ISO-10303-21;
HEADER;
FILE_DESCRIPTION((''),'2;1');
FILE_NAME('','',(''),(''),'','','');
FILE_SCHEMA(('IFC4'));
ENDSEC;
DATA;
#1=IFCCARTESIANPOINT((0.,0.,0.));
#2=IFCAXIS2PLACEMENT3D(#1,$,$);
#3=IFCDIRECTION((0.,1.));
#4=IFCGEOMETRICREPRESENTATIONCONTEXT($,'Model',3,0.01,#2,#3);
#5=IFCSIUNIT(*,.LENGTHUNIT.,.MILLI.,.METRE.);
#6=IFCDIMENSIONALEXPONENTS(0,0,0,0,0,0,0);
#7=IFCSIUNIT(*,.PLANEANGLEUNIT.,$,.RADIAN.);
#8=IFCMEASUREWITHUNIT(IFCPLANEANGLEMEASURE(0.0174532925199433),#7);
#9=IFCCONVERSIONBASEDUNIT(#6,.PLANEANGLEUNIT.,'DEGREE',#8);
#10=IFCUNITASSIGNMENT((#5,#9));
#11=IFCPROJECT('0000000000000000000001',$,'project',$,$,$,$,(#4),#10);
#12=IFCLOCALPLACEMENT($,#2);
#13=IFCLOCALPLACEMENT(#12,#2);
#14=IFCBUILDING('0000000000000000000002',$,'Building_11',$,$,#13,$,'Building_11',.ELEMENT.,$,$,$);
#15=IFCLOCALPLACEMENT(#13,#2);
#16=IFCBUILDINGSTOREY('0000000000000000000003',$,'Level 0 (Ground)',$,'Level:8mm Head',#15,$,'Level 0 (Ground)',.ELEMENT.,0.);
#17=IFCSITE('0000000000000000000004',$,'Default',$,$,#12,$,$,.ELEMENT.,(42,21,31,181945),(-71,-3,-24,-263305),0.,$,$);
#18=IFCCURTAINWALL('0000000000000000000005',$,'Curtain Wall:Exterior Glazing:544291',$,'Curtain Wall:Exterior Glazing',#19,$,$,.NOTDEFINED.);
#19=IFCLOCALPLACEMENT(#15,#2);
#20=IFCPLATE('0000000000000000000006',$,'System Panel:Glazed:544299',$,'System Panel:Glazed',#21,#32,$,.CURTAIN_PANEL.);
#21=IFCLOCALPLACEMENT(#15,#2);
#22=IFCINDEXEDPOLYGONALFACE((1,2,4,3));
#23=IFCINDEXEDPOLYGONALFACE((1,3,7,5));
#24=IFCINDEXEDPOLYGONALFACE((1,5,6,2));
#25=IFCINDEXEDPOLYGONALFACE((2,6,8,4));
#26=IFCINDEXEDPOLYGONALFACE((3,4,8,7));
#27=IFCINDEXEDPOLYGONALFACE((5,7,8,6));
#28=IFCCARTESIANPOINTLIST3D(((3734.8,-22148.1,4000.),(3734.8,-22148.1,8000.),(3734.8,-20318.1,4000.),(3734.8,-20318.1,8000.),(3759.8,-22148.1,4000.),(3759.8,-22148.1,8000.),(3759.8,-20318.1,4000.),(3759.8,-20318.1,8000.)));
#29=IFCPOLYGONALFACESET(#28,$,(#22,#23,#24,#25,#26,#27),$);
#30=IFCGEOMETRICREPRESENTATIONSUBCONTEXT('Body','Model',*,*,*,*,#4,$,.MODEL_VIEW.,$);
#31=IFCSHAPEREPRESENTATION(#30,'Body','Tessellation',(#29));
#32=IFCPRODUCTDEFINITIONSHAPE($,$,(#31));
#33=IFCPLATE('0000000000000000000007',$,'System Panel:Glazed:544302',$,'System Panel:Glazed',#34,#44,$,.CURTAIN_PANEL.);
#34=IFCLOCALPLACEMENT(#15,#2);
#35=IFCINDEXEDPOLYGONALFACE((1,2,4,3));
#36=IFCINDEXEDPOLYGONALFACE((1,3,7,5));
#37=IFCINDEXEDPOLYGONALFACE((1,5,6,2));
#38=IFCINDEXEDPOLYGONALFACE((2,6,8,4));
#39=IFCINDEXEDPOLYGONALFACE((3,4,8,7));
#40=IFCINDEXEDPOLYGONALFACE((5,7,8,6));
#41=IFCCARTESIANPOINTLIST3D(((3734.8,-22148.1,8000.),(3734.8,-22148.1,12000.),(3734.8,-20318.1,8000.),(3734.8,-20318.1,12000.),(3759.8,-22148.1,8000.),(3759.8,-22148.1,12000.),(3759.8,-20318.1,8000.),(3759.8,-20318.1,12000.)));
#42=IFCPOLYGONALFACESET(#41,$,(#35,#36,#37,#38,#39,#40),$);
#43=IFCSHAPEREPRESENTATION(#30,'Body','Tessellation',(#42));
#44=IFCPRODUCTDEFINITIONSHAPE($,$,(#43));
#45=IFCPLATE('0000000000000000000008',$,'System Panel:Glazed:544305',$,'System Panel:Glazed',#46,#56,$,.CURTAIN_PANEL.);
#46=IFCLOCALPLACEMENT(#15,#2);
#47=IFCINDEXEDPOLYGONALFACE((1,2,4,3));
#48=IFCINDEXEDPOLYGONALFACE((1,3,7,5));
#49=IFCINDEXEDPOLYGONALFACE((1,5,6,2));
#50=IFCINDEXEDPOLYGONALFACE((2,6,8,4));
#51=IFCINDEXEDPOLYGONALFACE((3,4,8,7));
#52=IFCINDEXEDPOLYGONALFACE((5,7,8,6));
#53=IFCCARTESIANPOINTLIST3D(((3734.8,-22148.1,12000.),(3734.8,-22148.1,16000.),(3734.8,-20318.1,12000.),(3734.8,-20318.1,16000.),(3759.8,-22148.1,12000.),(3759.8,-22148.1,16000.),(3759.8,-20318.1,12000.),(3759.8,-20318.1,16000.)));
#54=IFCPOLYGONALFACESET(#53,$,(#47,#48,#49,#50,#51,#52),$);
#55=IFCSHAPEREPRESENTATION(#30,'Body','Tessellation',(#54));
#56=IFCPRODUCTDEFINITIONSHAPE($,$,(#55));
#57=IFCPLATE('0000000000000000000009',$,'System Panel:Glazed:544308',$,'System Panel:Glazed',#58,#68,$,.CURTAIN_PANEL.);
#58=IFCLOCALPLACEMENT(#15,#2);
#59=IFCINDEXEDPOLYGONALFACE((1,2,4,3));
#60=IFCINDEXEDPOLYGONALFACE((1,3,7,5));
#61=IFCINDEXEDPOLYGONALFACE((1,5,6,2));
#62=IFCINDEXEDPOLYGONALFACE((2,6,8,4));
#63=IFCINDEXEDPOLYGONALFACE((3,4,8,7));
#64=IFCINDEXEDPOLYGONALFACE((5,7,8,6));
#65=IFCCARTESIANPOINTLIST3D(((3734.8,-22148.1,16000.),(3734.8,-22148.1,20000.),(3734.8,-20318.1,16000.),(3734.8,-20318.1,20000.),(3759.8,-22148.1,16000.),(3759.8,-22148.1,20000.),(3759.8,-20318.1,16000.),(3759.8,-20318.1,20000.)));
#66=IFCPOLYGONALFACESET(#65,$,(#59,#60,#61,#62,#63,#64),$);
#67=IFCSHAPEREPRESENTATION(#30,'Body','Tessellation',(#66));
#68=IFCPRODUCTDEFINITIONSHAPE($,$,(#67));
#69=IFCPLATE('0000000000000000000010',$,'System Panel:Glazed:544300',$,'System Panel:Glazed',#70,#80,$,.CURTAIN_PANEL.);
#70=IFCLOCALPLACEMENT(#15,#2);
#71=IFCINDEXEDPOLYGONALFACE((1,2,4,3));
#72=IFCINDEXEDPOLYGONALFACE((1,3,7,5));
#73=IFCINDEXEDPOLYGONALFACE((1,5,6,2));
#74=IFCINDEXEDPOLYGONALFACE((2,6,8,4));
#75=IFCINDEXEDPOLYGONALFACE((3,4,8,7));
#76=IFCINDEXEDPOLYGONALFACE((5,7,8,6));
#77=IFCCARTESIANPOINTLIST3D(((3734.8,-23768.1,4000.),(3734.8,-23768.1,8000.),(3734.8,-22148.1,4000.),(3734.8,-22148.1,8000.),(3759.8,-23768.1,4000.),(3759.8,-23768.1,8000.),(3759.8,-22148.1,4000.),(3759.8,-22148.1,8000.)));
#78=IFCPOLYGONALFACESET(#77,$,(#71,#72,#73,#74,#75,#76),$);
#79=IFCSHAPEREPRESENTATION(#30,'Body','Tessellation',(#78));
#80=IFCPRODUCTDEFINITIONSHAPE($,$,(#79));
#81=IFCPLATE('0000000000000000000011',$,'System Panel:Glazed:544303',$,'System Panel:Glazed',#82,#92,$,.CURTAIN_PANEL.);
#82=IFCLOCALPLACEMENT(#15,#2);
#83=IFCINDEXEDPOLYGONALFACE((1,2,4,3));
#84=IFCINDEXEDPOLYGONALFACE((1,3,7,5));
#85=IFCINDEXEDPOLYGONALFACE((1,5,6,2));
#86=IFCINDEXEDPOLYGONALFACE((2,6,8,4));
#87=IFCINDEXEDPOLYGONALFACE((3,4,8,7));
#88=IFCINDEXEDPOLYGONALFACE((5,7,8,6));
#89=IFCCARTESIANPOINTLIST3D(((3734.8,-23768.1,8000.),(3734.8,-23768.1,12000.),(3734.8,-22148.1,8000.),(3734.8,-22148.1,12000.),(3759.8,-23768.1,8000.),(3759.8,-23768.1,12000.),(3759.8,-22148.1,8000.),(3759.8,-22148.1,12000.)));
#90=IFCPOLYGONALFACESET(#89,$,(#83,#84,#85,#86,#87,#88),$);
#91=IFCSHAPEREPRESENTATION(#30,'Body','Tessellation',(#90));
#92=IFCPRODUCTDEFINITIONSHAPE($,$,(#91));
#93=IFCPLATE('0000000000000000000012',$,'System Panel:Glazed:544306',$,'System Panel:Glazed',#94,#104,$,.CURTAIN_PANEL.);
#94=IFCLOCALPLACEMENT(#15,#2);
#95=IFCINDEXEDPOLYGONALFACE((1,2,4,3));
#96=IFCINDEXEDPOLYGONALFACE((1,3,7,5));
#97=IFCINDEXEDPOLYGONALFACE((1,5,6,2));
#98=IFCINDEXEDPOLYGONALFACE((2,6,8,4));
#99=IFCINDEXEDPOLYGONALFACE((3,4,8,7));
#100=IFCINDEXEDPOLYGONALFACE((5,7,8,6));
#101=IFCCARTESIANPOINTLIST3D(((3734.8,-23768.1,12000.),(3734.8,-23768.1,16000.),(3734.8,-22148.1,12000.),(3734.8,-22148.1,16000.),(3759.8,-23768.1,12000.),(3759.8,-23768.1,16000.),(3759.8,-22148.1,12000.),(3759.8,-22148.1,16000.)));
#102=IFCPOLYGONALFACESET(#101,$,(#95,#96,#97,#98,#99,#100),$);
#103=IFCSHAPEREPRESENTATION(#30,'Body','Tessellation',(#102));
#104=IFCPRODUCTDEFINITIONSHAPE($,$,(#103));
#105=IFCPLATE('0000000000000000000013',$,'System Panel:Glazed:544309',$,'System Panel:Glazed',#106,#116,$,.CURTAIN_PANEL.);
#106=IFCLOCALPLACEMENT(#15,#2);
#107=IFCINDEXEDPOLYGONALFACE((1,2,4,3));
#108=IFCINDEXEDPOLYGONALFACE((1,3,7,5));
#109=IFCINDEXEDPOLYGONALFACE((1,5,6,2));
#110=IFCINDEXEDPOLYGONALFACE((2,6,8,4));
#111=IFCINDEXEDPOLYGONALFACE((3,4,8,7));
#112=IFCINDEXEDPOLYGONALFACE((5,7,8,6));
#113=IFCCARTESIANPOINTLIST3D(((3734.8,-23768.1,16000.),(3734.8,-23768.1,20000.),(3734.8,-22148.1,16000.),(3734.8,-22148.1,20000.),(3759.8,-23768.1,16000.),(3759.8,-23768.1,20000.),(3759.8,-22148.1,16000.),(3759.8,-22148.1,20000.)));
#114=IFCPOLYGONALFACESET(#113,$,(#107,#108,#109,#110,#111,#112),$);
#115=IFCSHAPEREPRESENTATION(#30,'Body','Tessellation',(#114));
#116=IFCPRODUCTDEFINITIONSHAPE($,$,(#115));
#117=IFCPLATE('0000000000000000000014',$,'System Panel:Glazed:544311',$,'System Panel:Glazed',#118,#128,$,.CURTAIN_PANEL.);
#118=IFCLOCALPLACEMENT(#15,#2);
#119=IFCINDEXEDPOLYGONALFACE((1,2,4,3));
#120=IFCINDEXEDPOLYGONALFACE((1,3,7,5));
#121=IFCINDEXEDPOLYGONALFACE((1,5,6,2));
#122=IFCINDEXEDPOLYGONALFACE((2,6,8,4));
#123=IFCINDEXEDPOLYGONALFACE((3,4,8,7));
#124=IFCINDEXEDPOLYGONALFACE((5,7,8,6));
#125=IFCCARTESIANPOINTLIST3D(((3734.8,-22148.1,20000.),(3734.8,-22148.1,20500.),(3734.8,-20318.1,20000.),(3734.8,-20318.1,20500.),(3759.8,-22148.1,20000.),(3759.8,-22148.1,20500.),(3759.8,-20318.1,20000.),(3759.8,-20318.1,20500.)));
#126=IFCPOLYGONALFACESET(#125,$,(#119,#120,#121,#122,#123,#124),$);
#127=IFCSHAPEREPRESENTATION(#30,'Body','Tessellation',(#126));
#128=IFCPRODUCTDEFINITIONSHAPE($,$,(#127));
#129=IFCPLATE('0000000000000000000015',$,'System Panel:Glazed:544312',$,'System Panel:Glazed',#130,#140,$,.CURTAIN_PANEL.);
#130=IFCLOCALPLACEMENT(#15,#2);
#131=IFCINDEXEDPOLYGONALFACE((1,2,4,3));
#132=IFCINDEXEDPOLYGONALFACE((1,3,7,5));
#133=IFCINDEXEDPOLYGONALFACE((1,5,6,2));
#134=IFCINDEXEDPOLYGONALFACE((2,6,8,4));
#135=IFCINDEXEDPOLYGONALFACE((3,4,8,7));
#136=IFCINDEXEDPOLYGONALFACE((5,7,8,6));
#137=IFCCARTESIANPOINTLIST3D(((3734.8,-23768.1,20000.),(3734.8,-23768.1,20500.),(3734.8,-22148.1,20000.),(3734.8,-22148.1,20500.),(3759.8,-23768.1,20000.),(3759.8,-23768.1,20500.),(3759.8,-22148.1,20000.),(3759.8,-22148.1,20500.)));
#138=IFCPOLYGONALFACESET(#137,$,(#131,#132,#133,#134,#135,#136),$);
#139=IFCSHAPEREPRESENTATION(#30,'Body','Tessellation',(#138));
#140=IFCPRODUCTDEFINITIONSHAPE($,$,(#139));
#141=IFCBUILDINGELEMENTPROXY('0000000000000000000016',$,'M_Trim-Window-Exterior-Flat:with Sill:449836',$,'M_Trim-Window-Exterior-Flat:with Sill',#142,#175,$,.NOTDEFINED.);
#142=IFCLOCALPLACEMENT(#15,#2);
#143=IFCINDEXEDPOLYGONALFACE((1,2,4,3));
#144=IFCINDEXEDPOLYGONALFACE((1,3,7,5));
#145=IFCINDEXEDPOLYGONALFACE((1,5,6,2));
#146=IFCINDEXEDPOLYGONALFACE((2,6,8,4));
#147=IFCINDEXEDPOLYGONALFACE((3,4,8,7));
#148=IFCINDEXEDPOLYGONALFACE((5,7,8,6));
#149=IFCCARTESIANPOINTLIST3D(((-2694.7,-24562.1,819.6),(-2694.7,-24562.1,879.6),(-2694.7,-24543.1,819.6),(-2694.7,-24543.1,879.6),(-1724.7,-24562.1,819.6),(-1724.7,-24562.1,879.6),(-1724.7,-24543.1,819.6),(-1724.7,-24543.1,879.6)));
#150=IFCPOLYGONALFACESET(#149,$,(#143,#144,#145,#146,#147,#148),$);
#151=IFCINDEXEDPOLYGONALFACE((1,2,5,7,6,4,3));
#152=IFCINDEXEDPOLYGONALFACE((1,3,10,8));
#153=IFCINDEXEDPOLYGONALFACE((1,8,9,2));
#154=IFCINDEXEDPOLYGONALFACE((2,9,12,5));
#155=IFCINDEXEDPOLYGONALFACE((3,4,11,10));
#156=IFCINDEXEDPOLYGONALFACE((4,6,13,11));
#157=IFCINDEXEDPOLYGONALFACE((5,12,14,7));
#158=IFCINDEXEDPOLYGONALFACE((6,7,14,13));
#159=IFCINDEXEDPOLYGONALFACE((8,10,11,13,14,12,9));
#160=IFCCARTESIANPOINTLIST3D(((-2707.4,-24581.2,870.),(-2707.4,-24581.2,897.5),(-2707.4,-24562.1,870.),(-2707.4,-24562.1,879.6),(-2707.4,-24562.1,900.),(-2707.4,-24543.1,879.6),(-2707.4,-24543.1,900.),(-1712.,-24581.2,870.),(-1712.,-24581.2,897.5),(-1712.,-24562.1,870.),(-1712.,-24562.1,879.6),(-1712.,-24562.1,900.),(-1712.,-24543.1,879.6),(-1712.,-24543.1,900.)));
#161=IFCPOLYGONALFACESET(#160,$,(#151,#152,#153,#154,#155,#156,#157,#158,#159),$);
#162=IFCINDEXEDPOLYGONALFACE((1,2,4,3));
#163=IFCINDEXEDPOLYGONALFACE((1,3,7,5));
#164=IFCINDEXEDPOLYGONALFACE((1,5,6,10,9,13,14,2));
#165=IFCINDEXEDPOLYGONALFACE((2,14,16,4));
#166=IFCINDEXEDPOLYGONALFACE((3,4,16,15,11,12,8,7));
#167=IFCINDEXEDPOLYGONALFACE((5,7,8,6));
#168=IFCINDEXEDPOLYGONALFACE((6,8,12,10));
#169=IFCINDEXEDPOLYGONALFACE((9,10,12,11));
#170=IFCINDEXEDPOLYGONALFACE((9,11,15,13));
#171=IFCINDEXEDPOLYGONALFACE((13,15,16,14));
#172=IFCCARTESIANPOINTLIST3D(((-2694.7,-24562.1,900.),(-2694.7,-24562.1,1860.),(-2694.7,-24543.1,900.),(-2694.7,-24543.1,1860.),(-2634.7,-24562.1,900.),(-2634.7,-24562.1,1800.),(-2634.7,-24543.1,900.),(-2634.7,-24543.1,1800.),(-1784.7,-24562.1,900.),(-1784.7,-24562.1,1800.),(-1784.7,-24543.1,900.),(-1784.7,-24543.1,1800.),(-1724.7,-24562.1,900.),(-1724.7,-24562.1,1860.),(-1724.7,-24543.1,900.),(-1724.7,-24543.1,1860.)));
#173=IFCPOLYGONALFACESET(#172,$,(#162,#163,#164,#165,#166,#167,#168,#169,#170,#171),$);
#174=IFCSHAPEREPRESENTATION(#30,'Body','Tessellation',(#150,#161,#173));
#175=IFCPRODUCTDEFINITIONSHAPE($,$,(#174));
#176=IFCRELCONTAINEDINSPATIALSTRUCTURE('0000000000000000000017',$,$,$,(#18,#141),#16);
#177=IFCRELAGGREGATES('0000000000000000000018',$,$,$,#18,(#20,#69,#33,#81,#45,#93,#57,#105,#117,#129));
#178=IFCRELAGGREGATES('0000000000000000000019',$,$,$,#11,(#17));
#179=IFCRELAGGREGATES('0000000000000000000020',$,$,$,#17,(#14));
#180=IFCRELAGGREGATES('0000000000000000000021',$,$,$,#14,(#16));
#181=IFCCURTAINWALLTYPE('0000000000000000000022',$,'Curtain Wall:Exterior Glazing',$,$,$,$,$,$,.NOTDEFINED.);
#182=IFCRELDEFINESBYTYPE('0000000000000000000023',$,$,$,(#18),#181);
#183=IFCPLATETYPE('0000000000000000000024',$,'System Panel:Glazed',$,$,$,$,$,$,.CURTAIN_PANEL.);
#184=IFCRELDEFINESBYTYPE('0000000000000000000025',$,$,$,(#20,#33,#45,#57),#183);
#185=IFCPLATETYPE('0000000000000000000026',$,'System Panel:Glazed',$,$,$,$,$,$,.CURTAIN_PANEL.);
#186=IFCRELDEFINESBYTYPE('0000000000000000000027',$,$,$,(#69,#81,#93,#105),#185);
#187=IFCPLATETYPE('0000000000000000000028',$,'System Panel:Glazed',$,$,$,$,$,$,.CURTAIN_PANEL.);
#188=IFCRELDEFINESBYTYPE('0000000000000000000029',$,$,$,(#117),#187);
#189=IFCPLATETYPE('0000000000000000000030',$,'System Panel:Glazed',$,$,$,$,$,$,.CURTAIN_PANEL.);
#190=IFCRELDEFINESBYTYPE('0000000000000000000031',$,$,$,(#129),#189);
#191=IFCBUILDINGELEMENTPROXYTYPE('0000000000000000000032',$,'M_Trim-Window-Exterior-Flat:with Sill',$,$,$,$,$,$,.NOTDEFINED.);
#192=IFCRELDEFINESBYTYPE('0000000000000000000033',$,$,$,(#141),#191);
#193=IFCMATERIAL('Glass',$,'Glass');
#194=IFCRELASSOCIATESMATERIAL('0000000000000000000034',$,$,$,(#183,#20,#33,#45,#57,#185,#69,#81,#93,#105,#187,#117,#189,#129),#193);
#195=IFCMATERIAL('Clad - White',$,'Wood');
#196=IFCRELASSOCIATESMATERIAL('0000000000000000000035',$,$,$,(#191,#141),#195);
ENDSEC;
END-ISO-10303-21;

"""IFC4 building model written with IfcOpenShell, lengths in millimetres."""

from ifc_helpers import new_model, entity, si_unit, converted_unit, direction, frame, origin, place, context, subcontext, project, spatial, indexed_curve, outline, extrude, source, transform, mapped, material, type_object, type_shapes, element, aggregate, save


model = new_model("IFC4")

# Units and contexts
model_context = context("Model", 3, precision=0.01, world=origin(), true_north=direction((0.0, 1.0)))
body_context = subcontext(model_context, "Body", "Model", "MODEL_VIEW")
ifc_project = project(units=[si_unit("LENGTHUNIT", "METRE", prefix="MILLI"), converted_unit("PLANEANGLEUNIT", "DEGREE", entity("IfcPlaneAngleMeasure", 0.0174532925199433), si_unit("PLANEANGLEUNIT", "RADIAN"), dimensions=[0, 0, 0, 0, 0, 0, 0])], contexts=[model_context])

# Site, building, storey
site_placement = place(None, origin())
site = spatial("IfcSite", under=ifc_project, at=site_placement, Name="Default", CompositionType="ELEMENT", RefLatitude=(42, 21, 31, 181945), RefLongitude=(-71, -3, -24, -263305), RefElevation=0.0)
building_placement = place(site_placement, origin())
building = spatial("IfcBuilding", under=site, at=building_placement, Name="Building_11", LongName="Building_11", CompositionType="ELEMENT")
storey_placement = place(building_placement, origin())
storey = spatial("IfcBuildingStorey", under=building, at=storey_placement, Name="Level 0 (Ground)", ObjectType="Level:8mm Head", LongName="Level 0 (Ground)", CompositionType="ELEMENT", Elevation=0.0)

# Curtain wall, plates
curtain_wall_type = type_object("IfcCurtainWallType", Name="Curtain Wall:Exterior Glazing", PredefinedType="NOTDEFINED")
curtain_wall_placement = place(storey_placement, origin())
curtain_wall = element("IfcCurtainWall", 1, at=curtain_wall_placement, inside=storey, type_object=curtain_wall_type, Name="Curtain Wall:Exterior Glazing:544291", ObjectType="Curtain Wall:Exterior Glazing", PredefinedType="NOTDEFINED")
ifc_material_1 = material(Name="Glass", Category="Glass")
plate_type_1 = type_object("IfcPlateType", Name="System Panel:Glazed", PredefinedType="CURTAIN_PANEL", material=ifc_material_1)
shared_shape_1 = source(origin(), body_context, "Body", "SweptSolid", [
    extrude(outline(indexed_curve([(-12.5, -915.0), (12.5, -915.0), (12.5, 915.0), (-12.5, 915.0), (-12.5, -915.0)], self_intersect=False)), frame((0.0, 37.0, 0.0), z_axis=(0.0, 0.0, 1.0), x_axis=(0.0, 1.0, 0.0)), (0.0, 0.0, 1.0), 4000.0),
])
type_shapes(plate_type_1, [shared_shape_1])
plate_1_placement = place(curtain_wall_placement, frame((3710.3, -21233.1, 4000.0), z_axis=(0.0, 0.0, 1.0), x_axis=(0.0, -1.0, 0.0)))
plate_1 = element("IfcPlate", 2, at=plate_1_placement, type_object=plate_type_1, material=ifc_material_1, Name="System Panel:Glazed:544299", ObjectType="System Panel:Glazed", PredefinedType="CURTAIN_PANEL", context=body_context, shape_type="MappedRepresentation", body=[
    mapped(shared_shape_1, transform((0.0, 0.0, 0.0), scale=1.0)),
])
plate_2_placement = place(curtain_wall_placement, frame((3710.3, -21233.1, 8000.0), z_axis=(0.0, 0.0, 1.0), x_axis=(0.0, -1.0, 0.0)))
plate_2 = element("IfcPlate", 3, at=plate_2_placement, type_object=plate_type_1, material=ifc_material_1, Name="System Panel:Glazed:544302", ObjectType="System Panel:Glazed", PredefinedType="CURTAIN_PANEL", context=body_context, shape_type="MappedRepresentation", body=[
    mapped(shared_shape_1, transform((0.0, 0.0, 0.0), scale=1.0)),
])
plate_3_placement = place(curtain_wall_placement, frame((3710.3, -21233.1, 12000.0), z_axis=(0.0, 0.0, 1.0), x_axis=(0.0, -1.0, 0.0)))
plate_3 = element("IfcPlate", 4, at=plate_3_placement, type_object=plate_type_1, material=ifc_material_1, Name="System Panel:Glazed:544305", ObjectType="System Panel:Glazed", PredefinedType="CURTAIN_PANEL", context=body_context, shape_type="MappedRepresentation", body=[
    mapped(shared_shape_1, transform((0.0, 0.0, 0.0), scale=1.0)),
])
plate_4_placement = place(curtain_wall_placement, frame((3710.3, -21233.1, 16000.0), z_axis=(0.0, 0.0, 1.0), x_axis=(0.0, -1.0, 0.0)))
plate_4 = element("IfcPlate", 5, at=plate_4_placement, type_object=plate_type_1, material=ifc_material_1, Name="System Panel:Glazed:544308", ObjectType="System Panel:Glazed", PredefinedType="CURTAIN_PANEL", context=body_context, shape_type="MappedRepresentation", body=[
    mapped(shared_shape_1, transform((0.0, 0.0, 0.0), scale=1.0)),
])
plate_type_2 = type_object("IfcPlateType", Name="System Panel:Glazed", PredefinedType="CURTAIN_PANEL", material=ifc_material_1)
shared_shape_2 = source(origin(), body_context, "Body", "SweptSolid", [
    extrude(outline(indexed_curve([(-12.5, -810.0), (12.5, -810.0), (12.5, 810.0), (-12.5, 810.0), (-12.5, -810.0)], self_intersect=False)), frame((0.0, 37.0, 0.0), z_axis=(0.0, 0.0, 1.0), x_axis=(0.0, 1.0, 0.0)), (0.0, 0.0, 1.0), 4000.0),
])
type_shapes(plate_type_2, [shared_shape_2])
plate_5_placement = place(curtain_wall_placement, frame((3710.3, -22958.1, 4000.0), z_axis=(0.0, 0.0, 1.0), x_axis=(0.0, -1.0, 0.0)))
plate_5 = element("IfcPlate", 6, at=plate_5_placement, type_object=plate_type_2, material=ifc_material_1, Name="System Panel:Glazed:544300", ObjectType="System Panel:Glazed", PredefinedType="CURTAIN_PANEL", context=body_context, shape_type="MappedRepresentation", body=[
    mapped(shared_shape_2, transform((0.0, 0.0, 0.0), scale=1.0)),
])
plate_6_placement = place(curtain_wall_placement, frame((3710.3, -22958.1, 8000.0), z_axis=(0.0, 0.0, 1.0), x_axis=(0.0, -1.0, 0.0)))
plate_6 = element("IfcPlate", 7, at=plate_6_placement, type_object=plate_type_2, material=ifc_material_1, Name="System Panel:Glazed:544303", ObjectType="System Panel:Glazed", PredefinedType="CURTAIN_PANEL", context=body_context, shape_type="MappedRepresentation", body=[
    mapped(shared_shape_2, transform((0.0, 0.0, 0.0), scale=1.0)),
])
plate_7_placement = place(curtain_wall_placement, frame((3710.3, -22958.1, 12000.0), z_axis=(0.0, 0.0, 1.0), x_axis=(0.0, -1.0, 0.0)))
plate_7 = element("IfcPlate", 8, at=plate_7_placement, type_object=plate_type_2, material=ifc_material_1, Name="System Panel:Glazed:544306", ObjectType="System Panel:Glazed", PredefinedType="CURTAIN_PANEL", context=body_context, shape_type="MappedRepresentation", body=[
    mapped(shared_shape_2, transform((0.0, 0.0, 0.0), scale=1.0)),
])
plate_8_placement = place(curtain_wall_placement, frame((3710.3, -22958.1, 16000.0), z_axis=(0.0, 0.0, 1.0), x_axis=(0.0, -1.0, 0.0)))
plate_8 = element("IfcPlate", 9, at=plate_8_placement, type_object=plate_type_2, material=ifc_material_1, Name="System Panel:Glazed:544309", ObjectType="System Panel:Glazed", PredefinedType="CURTAIN_PANEL", context=body_context, shape_type="MappedRepresentation", body=[
    mapped(shared_shape_2, transform((0.0, 0.0, 0.0), scale=1.0)),
])
plate_type_3 = type_object("IfcPlateType", Name="System Panel:Glazed", PredefinedType="CURTAIN_PANEL", material=ifc_material_1)
shared_shape_3 = source(origin(), body_context, "Body", "SweptSolid", [
    extrude(outline(indexed_curve([(-12.5, -915.0), (12.5, -915.0), (12.5, 915.0), (-12.5, 915.0), (-12.5, -915.0)], self_intersect=False)), frame((0.0, 37.0, 0.0), z_axis=(0.0, 0.0, 1.0), x_axis=(0.0, 1.0, 0.0)), (0.0, 0.0, 1.0), 500.0),
])
type_shapes(plate_type_3, [shared_shape_3])
plate_9_placement = place(curtain_wall_placement, frame((3710.3, -21233.1, 20000.0), z_axis=(0.0, 0.0, 1.0), x_axis=(0.0, -1.0, 0.0)))
plate_9 = element("IfcPlate", 10, at=plate_9_placement, type_object=plate_type_3, material=ifc_material_1, Name="System Panel:Glazed:544311", ObjectType="System Panel:Glazed", PredefinedType="CURTAIN_PANEL", context=body_context, shape_type="MappedRepresentation", body=[
    mapped(shared_shape_3, transform((0.0, 0.0, 0.0), scale=1.0)),
])
plate_type_4 = type_object("IfcPlateType", Name="System Panel:Glazed", PredefinedType="CURTAIN_PANEL", material=ifc_material_1)
shared_shape_4 = source(origin(), body_context, "Body", "SweptSolid", [
    extrude(outline(indexed_curve([(-12.5, -810.0), (12.5, -810.0), (12.5, 810.0), (-12.5, 810.0), (-12.5, -810.0)], self_intersect=False)), frame((0.0, 37.0, 0.0), z_axis=(0.0, 0.0, 1.0), x_axis=(0.0, 1.0, 0.0)), (0.0, 0.0, 1.0), 500.0),
])
type_shapes(plate_type_4, [shared_shape_4])
plate_10_placement = place(curtain_wall_placement, frame((3710.3, -22958.1, 20000.0), z_axis=(0.0, 0.0, 1.0), x_axis=(0.0, -1.0, 0.0)))
plate_10 = element("IfcPlate", 11, at=plate_10_placement, type_object=plate_type_4, material=ifc_material_1, Name="System Panel:Glazed:544312", ObjectType="System Panel:Glazed", PredefinedType="CURTAIN_PANEL", context=body_context, shape_type="MappedRepresentation", body=[
    mapped(shared_shape_4, transform((0.0, 0.0, 0.0), scale=1.0)),
])
aggregate(curtain_wall, [plate_1, plate_5, plate_2, plate_6, plate_3, plate_7, plate_4, plate_8, plate_9, plate_10])

# Building element proxy
ifc_material_2 = material(Name="Clad - White", Category="Wood")
building_element_proxy_type_1 = type_object("IfcBuildingElementProxyType", Name="M_Trim-Window-Exterior-Flat:with Sill", PredefinedType="NOTDEFINED", material=ifc_material_2)
shared_shape_5 = source(origin(), body_context, "Body", "SweptSolid", [
    extrude(outline(indexed_curve([(-485.0, -30.0), (485.0, -30.0), (485.0, 30.0), (-485.0, 30.0), (-485.0, -30.0)], self_intersect=False)), frame((0.0, -950.4, 0.0), z_axis=(0.0, 0.0, 1.0), x_axis=(-1.0, 0.0, 0.0)), (0.0, 0.0, 1.0), 19.1),
    extrude(outline(indexed_curve([(-19.0, -15.2), (0.0, -15.2), (0.0, -5.7), (19.0, -5.7), (19.0, 14.8), (0.0, 14.8), (-19.0, 12.3), (-19.0, -15.2)], self_intersect=False)), frame((-497.7, -914.8, 19.0), z_axis=(1.0, 0.0, 0.0), x_axis=(0.0, 0.0, -1.0)), (0.0, 0.0, 1.0), 995.4),
    extrude(outline(indexed_curve([(-495.0, -485.0), (465.0, -485.0), (465.0, -425.0), (-435.0, -425.0), (-435.0, 425.0), (465.0, 425.0), (465.0, 485.0), (-495.0, 485.0), (-495.0, -485.0)], self_intersect=False)), frame((0.0, -435.0, 0.0), z_axis=(0.0, 0.0, 1.0), x_axis=(0.0, -1.0, 0.0)), (0.0, 0.0, 1.0), 19.1),
])
type_shapes(building_element_proxy_type_1, [shared_shape_5])
for number, where, z_axis, x_axis, name in (
    (12, (-2209.7, -24543.1, 1800.0), (0.0, -1.0, 0.0), (1.0, 0.0, 0.0), "M_Trim-Window-Exterior-Flat:with Sill:449836"),
):
    element("IfcBuildingElementProxy", number, at=place(storey_placement, frame(where, z_axis=z_axis, x_axis=x_axis)), inside=storey, type_object=building_element_proxy_type_1, material=ifc_material_2, Name=name, ObjectType="M_Trim-Window-Exterior-Flat:with Sill", PredefinedType="NOTDEFINED", context=body_context, shape_type="MappedRepresentation", body=[
        mapped(shared_shape_5, transform((0.0, 0.0, 0.0), scale=1.0)),
    ])

save(model, "model.ifc")
